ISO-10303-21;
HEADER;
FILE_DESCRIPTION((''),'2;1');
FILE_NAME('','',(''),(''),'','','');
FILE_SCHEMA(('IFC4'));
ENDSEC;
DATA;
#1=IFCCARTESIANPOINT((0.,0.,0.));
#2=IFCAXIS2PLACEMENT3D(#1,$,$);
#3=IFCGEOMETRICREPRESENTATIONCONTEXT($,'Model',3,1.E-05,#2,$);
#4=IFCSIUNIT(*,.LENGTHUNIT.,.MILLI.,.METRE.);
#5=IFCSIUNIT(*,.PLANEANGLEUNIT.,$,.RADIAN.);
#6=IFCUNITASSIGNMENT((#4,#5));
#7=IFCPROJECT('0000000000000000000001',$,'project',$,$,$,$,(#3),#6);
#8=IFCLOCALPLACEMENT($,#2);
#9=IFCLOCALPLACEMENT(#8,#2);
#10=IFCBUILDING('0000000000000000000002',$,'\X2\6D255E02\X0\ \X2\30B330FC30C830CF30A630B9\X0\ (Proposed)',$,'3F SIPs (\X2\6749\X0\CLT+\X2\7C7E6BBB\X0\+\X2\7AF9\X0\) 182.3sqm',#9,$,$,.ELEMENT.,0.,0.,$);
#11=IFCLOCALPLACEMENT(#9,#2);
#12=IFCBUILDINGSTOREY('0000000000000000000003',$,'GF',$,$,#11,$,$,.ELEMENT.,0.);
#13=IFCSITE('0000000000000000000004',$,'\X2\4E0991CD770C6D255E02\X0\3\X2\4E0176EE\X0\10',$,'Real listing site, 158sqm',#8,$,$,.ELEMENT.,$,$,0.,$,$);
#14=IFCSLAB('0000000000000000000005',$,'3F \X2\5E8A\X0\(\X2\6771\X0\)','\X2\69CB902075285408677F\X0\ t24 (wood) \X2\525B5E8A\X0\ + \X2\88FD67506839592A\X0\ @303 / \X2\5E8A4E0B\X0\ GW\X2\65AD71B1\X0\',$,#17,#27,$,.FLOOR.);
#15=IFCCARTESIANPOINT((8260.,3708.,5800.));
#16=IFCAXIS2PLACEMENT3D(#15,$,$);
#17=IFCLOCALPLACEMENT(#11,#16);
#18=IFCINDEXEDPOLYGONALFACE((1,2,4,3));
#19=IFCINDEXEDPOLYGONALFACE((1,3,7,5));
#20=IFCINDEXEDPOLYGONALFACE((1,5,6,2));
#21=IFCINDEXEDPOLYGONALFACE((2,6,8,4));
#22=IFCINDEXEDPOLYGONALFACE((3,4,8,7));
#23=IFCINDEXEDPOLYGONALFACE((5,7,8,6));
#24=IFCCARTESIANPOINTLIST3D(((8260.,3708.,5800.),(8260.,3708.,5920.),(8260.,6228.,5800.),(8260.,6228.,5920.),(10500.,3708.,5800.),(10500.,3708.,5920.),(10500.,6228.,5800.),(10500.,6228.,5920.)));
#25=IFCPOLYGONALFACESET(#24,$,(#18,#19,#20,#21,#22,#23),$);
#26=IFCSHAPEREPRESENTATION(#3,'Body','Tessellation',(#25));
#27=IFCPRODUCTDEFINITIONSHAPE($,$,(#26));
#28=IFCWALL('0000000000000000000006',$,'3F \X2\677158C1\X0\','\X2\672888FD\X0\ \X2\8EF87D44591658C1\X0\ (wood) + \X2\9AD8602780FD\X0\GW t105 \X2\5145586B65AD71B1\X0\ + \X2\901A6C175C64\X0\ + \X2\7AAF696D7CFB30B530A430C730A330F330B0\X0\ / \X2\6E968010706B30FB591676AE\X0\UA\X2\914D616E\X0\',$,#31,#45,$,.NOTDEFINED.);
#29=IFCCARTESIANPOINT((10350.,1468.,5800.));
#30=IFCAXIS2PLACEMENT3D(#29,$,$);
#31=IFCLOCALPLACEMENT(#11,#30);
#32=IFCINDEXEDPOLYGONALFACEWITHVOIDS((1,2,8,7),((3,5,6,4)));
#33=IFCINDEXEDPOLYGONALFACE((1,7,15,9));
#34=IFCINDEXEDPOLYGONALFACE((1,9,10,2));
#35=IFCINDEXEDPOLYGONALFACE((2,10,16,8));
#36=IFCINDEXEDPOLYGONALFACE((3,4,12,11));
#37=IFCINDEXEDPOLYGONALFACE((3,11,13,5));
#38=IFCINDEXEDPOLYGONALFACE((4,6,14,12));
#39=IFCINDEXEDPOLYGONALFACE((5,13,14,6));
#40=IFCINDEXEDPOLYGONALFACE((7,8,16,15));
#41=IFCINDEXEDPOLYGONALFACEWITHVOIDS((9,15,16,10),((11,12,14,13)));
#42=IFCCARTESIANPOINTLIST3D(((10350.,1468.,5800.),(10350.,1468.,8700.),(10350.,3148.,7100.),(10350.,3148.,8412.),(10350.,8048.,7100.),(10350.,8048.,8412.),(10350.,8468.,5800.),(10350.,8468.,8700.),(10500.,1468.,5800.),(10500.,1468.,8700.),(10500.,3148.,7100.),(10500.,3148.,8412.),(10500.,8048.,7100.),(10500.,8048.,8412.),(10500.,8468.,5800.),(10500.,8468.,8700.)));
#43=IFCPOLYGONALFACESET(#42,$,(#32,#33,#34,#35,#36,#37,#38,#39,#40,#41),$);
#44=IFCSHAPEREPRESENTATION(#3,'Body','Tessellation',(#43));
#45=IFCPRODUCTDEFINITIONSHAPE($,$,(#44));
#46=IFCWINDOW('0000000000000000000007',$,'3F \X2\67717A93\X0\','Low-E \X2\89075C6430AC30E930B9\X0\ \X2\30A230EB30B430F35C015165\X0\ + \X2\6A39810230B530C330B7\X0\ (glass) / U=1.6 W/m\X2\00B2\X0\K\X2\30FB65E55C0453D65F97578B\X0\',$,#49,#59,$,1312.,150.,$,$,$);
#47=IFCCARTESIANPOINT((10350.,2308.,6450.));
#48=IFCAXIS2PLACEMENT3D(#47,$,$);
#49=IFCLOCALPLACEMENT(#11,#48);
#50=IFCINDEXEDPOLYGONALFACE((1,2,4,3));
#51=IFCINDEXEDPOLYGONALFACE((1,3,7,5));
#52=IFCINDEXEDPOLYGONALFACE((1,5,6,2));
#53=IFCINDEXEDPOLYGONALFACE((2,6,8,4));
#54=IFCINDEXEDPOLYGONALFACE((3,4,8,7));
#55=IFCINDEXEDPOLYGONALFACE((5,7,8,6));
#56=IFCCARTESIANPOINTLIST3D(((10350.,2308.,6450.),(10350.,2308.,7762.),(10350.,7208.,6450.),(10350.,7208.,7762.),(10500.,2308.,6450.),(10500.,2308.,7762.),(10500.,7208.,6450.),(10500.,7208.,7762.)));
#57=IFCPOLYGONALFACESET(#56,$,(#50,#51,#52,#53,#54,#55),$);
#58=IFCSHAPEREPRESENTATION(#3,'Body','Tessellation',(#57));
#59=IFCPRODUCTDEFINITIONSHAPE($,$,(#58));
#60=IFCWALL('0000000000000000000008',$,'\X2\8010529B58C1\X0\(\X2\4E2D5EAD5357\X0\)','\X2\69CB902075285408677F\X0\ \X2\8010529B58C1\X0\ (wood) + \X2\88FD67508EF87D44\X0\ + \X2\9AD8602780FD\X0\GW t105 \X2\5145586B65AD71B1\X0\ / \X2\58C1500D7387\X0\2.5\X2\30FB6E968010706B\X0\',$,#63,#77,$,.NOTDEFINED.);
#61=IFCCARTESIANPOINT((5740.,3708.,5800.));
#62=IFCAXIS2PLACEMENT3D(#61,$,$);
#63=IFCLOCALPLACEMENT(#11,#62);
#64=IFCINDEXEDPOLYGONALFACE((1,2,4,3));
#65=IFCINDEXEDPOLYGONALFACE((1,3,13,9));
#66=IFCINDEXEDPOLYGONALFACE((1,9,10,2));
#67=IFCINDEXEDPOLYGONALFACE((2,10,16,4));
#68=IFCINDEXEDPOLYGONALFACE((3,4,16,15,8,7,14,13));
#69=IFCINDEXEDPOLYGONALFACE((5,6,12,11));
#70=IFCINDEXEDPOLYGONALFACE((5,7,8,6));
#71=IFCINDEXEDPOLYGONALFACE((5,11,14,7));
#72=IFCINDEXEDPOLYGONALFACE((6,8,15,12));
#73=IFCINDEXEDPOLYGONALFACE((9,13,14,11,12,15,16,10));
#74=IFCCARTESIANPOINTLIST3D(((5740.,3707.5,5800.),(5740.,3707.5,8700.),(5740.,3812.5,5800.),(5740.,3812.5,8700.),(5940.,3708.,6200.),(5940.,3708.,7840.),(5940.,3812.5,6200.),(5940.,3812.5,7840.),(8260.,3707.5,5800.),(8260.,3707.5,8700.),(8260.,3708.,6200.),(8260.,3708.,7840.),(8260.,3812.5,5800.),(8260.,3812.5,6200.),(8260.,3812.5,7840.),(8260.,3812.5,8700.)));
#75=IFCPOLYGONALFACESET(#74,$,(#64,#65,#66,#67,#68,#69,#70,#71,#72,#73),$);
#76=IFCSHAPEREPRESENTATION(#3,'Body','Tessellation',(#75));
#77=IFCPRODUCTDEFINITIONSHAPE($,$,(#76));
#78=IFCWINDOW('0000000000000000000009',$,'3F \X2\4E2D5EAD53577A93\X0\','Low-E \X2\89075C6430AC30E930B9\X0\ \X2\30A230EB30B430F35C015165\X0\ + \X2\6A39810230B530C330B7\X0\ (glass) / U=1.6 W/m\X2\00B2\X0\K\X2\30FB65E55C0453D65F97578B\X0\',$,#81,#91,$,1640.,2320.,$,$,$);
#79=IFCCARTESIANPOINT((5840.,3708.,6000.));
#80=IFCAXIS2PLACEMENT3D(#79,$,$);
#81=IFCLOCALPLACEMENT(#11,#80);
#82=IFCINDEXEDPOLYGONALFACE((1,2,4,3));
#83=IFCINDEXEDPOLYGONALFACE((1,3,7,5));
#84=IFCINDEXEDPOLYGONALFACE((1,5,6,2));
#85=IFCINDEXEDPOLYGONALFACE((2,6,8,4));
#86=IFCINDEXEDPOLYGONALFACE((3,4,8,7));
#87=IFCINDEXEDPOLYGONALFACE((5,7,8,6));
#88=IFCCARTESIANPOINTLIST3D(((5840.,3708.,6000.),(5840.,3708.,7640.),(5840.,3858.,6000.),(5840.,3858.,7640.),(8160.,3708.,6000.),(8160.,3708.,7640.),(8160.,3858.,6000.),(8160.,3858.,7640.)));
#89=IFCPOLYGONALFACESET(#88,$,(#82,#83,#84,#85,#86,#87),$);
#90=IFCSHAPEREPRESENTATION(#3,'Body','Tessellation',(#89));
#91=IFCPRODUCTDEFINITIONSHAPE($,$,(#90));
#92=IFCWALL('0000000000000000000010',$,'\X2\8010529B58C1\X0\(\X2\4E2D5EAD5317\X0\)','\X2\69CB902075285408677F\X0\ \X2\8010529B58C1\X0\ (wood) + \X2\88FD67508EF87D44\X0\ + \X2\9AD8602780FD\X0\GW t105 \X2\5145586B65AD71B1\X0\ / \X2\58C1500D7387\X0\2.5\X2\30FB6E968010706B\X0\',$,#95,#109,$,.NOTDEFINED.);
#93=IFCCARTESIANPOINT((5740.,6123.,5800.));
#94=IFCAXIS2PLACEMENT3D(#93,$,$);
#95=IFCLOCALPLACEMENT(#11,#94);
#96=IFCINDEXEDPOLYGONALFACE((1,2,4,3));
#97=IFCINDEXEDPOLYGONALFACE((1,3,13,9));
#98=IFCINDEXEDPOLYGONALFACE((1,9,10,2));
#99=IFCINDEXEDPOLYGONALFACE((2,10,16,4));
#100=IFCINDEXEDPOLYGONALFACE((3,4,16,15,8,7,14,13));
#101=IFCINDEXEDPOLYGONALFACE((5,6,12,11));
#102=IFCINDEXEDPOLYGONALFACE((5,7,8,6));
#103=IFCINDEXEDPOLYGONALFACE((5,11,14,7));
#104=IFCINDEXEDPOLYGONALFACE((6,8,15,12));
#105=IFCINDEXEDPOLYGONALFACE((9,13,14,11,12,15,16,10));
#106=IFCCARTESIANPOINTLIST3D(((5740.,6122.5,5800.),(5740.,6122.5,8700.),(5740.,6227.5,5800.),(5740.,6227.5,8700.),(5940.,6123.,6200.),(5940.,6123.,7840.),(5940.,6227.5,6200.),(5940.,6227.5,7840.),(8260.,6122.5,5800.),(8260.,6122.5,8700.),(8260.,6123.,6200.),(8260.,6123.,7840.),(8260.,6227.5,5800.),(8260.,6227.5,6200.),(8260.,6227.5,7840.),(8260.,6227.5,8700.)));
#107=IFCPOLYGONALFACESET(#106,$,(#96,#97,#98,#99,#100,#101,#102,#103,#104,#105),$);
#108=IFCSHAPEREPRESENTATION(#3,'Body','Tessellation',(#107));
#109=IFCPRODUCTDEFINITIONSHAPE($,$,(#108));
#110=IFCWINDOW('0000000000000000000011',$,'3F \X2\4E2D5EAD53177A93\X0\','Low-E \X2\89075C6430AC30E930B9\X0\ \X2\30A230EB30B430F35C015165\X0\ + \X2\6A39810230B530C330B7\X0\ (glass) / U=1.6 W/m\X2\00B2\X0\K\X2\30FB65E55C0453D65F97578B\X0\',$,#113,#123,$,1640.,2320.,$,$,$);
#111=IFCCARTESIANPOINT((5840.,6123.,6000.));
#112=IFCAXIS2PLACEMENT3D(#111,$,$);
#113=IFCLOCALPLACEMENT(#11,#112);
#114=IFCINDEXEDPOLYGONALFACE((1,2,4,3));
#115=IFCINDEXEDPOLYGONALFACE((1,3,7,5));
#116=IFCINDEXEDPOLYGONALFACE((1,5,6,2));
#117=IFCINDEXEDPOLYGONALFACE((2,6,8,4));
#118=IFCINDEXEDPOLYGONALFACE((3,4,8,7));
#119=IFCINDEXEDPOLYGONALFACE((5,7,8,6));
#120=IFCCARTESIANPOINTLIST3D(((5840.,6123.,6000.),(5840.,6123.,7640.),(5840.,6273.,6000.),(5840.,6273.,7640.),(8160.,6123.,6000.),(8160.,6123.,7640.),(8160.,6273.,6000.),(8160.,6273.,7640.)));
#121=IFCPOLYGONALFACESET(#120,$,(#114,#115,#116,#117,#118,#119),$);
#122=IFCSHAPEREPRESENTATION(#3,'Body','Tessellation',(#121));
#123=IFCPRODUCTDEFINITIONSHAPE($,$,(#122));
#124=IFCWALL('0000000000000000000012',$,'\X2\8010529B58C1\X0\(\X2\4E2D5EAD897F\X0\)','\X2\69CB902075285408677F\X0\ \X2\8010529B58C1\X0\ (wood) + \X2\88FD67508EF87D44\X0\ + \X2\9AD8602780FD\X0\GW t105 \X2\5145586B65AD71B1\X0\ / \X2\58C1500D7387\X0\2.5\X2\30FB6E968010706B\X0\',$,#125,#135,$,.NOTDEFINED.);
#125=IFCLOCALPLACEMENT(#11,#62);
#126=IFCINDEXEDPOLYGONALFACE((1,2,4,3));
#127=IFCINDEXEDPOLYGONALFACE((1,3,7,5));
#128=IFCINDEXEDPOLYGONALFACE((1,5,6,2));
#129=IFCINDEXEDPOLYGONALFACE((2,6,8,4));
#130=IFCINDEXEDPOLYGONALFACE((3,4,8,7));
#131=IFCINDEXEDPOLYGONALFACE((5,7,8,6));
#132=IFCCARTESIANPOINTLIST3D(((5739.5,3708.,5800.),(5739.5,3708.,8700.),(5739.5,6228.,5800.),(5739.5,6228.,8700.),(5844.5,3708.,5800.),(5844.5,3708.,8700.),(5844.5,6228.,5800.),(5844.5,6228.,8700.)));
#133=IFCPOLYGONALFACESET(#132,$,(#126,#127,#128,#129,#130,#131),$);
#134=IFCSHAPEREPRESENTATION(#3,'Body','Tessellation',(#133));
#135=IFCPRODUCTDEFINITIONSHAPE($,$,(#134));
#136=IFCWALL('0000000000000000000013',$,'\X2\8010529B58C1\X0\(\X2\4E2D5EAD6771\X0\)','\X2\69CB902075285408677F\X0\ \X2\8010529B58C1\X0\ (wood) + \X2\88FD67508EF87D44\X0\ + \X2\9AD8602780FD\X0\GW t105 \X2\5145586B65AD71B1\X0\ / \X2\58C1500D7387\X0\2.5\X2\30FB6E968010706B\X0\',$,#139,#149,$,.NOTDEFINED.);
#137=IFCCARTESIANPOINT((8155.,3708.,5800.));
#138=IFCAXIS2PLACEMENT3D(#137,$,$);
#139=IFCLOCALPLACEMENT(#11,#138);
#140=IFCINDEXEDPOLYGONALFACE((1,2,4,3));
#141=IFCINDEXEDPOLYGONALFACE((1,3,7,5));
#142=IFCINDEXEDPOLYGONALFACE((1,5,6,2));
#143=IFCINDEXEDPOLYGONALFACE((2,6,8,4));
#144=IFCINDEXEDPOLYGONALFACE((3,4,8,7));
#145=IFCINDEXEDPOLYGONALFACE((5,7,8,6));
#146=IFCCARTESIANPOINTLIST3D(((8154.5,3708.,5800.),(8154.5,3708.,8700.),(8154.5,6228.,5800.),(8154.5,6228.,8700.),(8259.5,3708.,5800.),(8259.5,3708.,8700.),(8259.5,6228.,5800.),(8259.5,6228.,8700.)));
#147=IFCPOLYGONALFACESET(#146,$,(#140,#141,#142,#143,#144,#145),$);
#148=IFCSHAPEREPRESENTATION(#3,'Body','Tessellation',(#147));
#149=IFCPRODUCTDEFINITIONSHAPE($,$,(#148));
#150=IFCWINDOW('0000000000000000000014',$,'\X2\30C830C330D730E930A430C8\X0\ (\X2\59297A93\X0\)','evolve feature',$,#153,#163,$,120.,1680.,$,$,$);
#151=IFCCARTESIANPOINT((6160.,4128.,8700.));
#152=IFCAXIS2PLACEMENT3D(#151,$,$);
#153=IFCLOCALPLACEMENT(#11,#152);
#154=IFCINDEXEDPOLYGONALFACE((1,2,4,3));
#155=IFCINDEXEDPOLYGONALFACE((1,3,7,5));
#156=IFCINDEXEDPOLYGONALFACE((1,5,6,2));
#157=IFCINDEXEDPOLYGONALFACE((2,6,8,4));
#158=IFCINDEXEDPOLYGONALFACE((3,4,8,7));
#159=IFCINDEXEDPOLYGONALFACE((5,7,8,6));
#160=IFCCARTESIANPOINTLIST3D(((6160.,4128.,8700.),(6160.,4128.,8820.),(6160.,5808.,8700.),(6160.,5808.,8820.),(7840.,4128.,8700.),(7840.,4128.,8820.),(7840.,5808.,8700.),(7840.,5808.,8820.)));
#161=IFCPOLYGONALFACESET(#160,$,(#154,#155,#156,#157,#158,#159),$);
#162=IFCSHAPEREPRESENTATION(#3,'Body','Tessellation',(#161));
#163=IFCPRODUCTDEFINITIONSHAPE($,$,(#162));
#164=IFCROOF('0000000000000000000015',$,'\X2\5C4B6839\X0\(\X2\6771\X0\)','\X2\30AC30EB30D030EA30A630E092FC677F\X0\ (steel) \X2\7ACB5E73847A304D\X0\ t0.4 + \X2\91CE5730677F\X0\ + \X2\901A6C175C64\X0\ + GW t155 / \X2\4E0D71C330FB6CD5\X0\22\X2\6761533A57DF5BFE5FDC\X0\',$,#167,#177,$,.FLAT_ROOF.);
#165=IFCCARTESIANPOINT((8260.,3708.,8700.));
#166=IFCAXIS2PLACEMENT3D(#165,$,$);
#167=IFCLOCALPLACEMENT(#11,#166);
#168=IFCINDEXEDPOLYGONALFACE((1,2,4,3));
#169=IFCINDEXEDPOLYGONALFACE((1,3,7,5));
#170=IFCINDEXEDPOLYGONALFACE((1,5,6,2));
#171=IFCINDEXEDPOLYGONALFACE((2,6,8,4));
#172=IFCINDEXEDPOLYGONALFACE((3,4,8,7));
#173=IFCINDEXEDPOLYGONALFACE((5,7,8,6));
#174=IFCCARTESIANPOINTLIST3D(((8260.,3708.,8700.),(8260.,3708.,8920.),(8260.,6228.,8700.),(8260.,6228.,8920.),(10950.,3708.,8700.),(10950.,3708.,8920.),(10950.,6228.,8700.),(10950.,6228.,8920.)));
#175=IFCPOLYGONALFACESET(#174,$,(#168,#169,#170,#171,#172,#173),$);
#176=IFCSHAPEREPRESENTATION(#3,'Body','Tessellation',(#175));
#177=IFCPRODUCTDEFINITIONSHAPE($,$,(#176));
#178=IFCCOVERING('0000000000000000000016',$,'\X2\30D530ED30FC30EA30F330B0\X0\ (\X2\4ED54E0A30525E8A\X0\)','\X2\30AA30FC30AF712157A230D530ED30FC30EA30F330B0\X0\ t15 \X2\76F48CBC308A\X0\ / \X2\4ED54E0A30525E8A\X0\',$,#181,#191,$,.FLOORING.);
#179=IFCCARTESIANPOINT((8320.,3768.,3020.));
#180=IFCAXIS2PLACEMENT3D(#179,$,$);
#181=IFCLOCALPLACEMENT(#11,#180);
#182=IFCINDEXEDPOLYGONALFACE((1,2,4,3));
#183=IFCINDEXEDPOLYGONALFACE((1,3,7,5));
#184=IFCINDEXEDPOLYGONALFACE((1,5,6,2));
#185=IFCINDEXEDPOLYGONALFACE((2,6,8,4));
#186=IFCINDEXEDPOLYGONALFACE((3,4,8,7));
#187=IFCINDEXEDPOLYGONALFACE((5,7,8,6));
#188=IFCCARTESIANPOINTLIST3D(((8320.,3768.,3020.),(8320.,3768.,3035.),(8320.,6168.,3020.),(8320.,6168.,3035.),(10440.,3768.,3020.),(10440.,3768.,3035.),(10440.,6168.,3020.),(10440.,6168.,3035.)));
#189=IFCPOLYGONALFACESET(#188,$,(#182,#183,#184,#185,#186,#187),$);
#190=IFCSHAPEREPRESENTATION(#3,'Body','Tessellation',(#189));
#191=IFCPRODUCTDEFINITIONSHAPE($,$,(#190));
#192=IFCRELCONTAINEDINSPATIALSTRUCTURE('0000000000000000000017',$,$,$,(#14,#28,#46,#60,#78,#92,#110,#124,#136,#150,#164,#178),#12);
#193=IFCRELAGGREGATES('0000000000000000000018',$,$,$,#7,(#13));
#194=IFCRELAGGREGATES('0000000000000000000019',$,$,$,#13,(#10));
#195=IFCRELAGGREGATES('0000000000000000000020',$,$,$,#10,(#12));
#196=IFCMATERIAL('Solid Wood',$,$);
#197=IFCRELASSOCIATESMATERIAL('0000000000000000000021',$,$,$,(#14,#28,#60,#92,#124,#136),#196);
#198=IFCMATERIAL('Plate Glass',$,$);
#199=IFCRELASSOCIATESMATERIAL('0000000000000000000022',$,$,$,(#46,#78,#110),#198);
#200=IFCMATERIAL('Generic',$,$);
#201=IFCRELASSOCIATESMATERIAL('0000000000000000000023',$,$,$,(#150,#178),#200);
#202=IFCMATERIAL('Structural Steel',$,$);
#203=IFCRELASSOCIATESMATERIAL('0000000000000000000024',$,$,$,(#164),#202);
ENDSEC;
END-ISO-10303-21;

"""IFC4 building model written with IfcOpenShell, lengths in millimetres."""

from ifc_helpers import new_model, si_unit, frame, frame_2d, origin, place, context, project, spatial, rectangle, extrude, material, element, fill, save


model = new_model("IFC4")

# Units and contexts
model_context = context("Model", 3, precision=1e-05, world=origin())
ifc_project = project(units=[si_unit("LENGTHUNIT", "METRE", prefix="MILLI"), si_unit("PLANEANGLEUNIT", "RADIAN")], contexts=[model_context])

# Site, building, storey
site_placement = place(None, origin())
site = spatial("IfcSite", under=ifc_project, at=site_placement, Name="三重県津市3丁目10", ObjectType="Real listing site, 158sqm", CompositionType="ELEMENT", RefElevation=0.0)
building_placement = place(site_placement, origin())
building = spatial("IfcBuilding", under=site, at=building_placement, Name="津市 コートハウス (Proposed)", ObjectType="3F SIPs (杉CLT+籾殻+竹) 182.3sqm", CompositionType="ELEMENT", ElevationOfRefHeight=0.0, ElevationOfTerrain=0.0)
storey_placement = place(building_placement, origin())
storey = spatial("IfcBuildingStorey", under=building, at=storey_placement, Name="GF", CompositionType="ELEMENT", Elevation=0.0)

# Slab
ifc_material_1 = material(Name="Solid Wood")
slab_placement = place(storey_placement, frame((8260.0, 3708.0, 5800.0)))
element("IfcSlab", 1, at=slab_placement, inside=storey, material=ifc_material_1, Name="3F 床(東)", Description="構造用合板 t24 (wood) 剛床 + 製材根太 @303 / 床下 GW断熱", PredefinedType="FLOOR", context=model_context, shape_type="SweptSolid", body=[
    extrude(rectangle(XDim=2240.0, YDim=2520.0, at=frame_2d((1120.0, 1260.0))), frame((8260.0, 3708.0, 5800.0)), (0.0, 0.0, 1.0), 120.0),
])

# Walls, openings, windows
wall_1_placement = place(storey_placement, frame((10350.0, 1468.0, 5800.0)))
wall_1 = element("IfcWall", 2, at=wall_1_placement, inside=storey, material=ifc_material_1, Name="3F 東壁", Description="木製 軸組外壁 (wood) + 高性能GW t105 充填断熱 + 通気層 + 窯業系サイディング / 準耐火・外皮UA配慮", PredefinedType="NOTDEFINED", context=model_context, shape_type="SweptSolid", body=[
    extrude(rectangle(XDim=150.0, YDim=7000.0, at=frame_2d((75.0, 3500.0))), frame((10350.0, 1468.0, 5800.0)), (0.0, 0.0, 1.0), 2900.0),
])
opening_1_placement = place(storey_placement, frame((10350.0, 2308.0, 6450.0)))
opening_1 = element("IfcOpeningElement", 3, at=opening_1_placement, cuts=wall_1, PredefinedType="NOTDEFINED", context=model_context, shape_type="SweptSolid", body=[
    extrude(rectangle(XDim=150.0, YDim=4900.0, at=frame_2d((75.0, 2450.0))), frame((10350.0, 2308.0, 6450.0)), (0.0, 0.0, 1.0), 1312.0),
])
ifc_material_2 = material(Name="Plate Glass")
window_1_placement = place(storey_placement, frame((10350.0, 2308.0, 6450.0)))
window_1 = element("IfcWindow", 4, at=window_1_placement, inside=storey, material=ifc_material_2, Name="3F 東窓", Description="Low-E 複層ガラス アルゴン封入 + 樹脂サッシ (glass) / U=1.6 W/m²K・日射取得型", OverallHeight=1312.0, OverallWidth=150.0, context=model_context, shape_type="SweptSolid", body=[
    extrude(rectangle(XDim=150.0, YDim=4900.0, at=frame_2d((75.0, 2450.0))), frame((10350.0, 2308.0, 6450.0)), (0.0, 0.0, 1.0), 1312.0),
])
fill(opening_1, window_1)
wall_2_placement = place(storey_placement, frame((5740.0, 3708.0, 5800.0)))
wall_2 = element("IfcWall", 5, at=wall_2_placement, inside=storey, material=ifc_material_1, Name="耐力壁(中庭南)", Description="構造用合板 耐力壁 (wood) + 製材軸組 + 高性能GW t105 充填断熱 / 壁倍率2.5・準耐火", PredefinedType="NOTDEFINED", context=model_context, shape_type="SweptSolid", body=[
    extrude(rectangle(XDim=2520.0, YDim=105.0, at=frame_2d((1260.0, 52.0))), frame((5740.0, 3708.0, 5800.0)), (0.0, 0.0, 1.0), 2900.0),
])
opening_2_placement = place(storey_placement, frame((5840.0, 3708.0, 6000.0)))
opening_2 = element("IfcOpeningElement", 6, at=opening_2_placement, cuts=wall_2, PredefinedType="NOTDEFINED", context=model_context, shape_type="SweptSolid", body=[
    extrude(rectangle(XDim=2320.0, YDim=150.0, at=frame_2d((1160.0, 75.0))), frame((5840.0, 3708.0, 6000.0)), (0.0, 0.0, 1.0), 1640.0),
])
window_2_placement = place(storey_placement, frame((5840.0, 3708.0, 6000.0)))
window_2 = element("IfcWindow", 7, at=window_2_placement, inside=storey, material=ifc_material_2, Name="3F 中庭南窓", Description="Low-E 複層ガラス アルゴン封入 + 樹脂サッシ (glass) / U=1.6 W/m²K・日射取得型", OverallHeight=1640.0, OverallWidth=2320.0, context=model_context, shape_type="SweptSolid", body=[
    extrude(rectangle(XDim=2320.0, YDim=150.0, at=frame_2d((1160.0, 75.0))), frame((5840.0, 3708.0, 6000.0)), (0.0, 0.0, 1.0), 1640.0),
])
fill(opening_2, window_2)
wall_3_placement = place(storey_placement, frame((5740.0, 6123.0, 5800.0)))
wall_3 = element("IfcWall", 8, at=wall_3_placement, inside=storey, material=ifc_material_1, Name="耐力壁(中庭北)", Description="構造用合板 耐力壁 (wood) + 製材軸組 + 高性能GW t105 充填断熱 / 壁倍率2.5・準耐火", PredefinedType="NOTDEFINED", context=model_context, shape_type="SweptSolid", body=[
    extrude(rectangle(XDim=2520.0, YDim=105.0, at=frame_2d((1260.0, 52.0))), frame((5740.0, 6123.0, 5800.0)), (0.0, 0.0, 1.0), 2900.0),
])
opening_3_placement = place(storey_placement, frame((5840.0, 6123.0, 6000.0)))
opening_3 = element("IfcOpeningElement", 9, at=opening_3_placement, cuts=wall_3, PredefinedType="NOTDEFINED", context=model_context, shape_type="SweptSolid", body=[
    extrude(rectangle(XDim=2320.0, YDim=150.0, at=frame_2d((1160.0, 75.0))), frame((5840.0, 6123.0, 6000.0)), (0.0, 0.0, 1.0), 1640.0),
])
window_3_placement = place(storey_placement, frame((5840.0, 6123.0, 6000.0)))
window_3 = element("IfcWindow", 10, at=window_3_placement, inside=storey, material=ifc_material_2, Name="3F 中庭北窓", Description="Low-E 複層ガラス アルゴン封入 + 樹脂サッシ (glass) / U=1.6 W/m²K・日射取得型", OverallHeight=1640.0, OverallWidth=2320.0, context=model_context, shape_type="SweptSolid", body=[
    extrude(rectangle(XDim=2320.0, YDim=150.0, at=frame_2d((1160.0, 75.0))), frame((5840.0, 6123.0, 6000.0)), (0.0, 0.0, 1.0), 1640.0),
])
fill(opening_3, window_3)

# Walls
wall_4_placement = place(storey_placement, frame((5740.0, 3708.0, 5800.0)))
element("IfcWall", 11, at=wall_4_placement, inside=storey, material=ifc_material_1, Name="耐力壁(中庭西)", Description="構造用合板 耐力壁 (wood) + 製材軸組 + 高性能GW t105 充填断熱 / 壁倍率2.5・準耐火", PredefinedType="NOTDEFINED", context=model_context, shape_type="SweptSolid", body=[
    extrude(rectangle(XDim=105.0, YDim=2520.0, at=frame_2d((52.0, 1260.0))), frame((5740.0, 3708.0, 5800.0)), (0.0, 0.0, 1.0), 2900.0),
])
wall_5_placement = place(storey_placement, frame((8155.0, 3708.0, 5800.0)))
element("IfcWall", 12, at=wall_5_placement, inside=storey, material=ifc_material_1, Name="耐力壁(中庭東)", Description="構造用合板 耐力壁 (wood) + 製材軸組 + 高性能GW t105 充填断熱 / 壁倍率2.5・準耐火", PredefinedType="NOTDEFINED", context=model_context, shape_type="SweptSolid", body=[
    extrude(rectangle(XDim=105.0, YDim=2520.0, at=frame_2d((52.0, 1260.0))), frame((8155.0, 3708.0, 5800.0)), (0.0, 0.0, 1.0), 2900.0),
])

# Window
ifc_material_3 = material(Name="Generic")
window_4_placement = place(storey_placement, frame((6160.0, 4128.0, 8700.0)))
element("IfcWindow", 13, at=window_4_placement, inside=storey, material=ifc_material_3, Name="トップライト (天窓)", Description="evolve feature", OverallHeight=120.0, OverallWidth=1680.0, context=model_context, shape_type="SweptSolid", body=[
    extrude(rectangle(XDim=1680.0, YDim=1680.0, at=frame_2d((840.0, 840.0))), frame((6160.0, 4128.0, 8700.0)), (0.0, 0.0, 1.0), 120.0),
])

# Roof
ifc_material_4 = material(Name="Structural Steel")
for number, where, name in (
    (14, (8260.0, 3708.0, 8700.0), "屋根(東)"),
):
    element("IfcRoof", number, at=place(storey_placement, frame(where)), inside=storey, material=ifc_material_4, Name=name, Description="ガルバリウム鋼板 (steel) 立平葺き t0.4 + 野地板 + 通気層 + GW t155 / 不燃・法22条区域対応", PredefinedType="FLAT_ROOF", context=model_context, shape_type="SweptSolid", body=[
        extrude(rectangle(XDim=2690.0, YDim=2520.0, at=frame_2d((1345.0, 1260.0))), frame((8260.0, 3708.0, 8700.0)), (0.0, 0.0, 1.0), 220.0),
    ])

# Covering
covering_1_placement = place(storey_placement, frame((8320.0, 3768.0, 3020.0)))
element("IfcCovering", 15, at=covering_1_placement, inside=storey, material=ifc_material_3, Name="フローリング (仕上げ床)", Description="オーク無垢フローリング t15 直貼り / 仕上げ床", PredefinedType="FLOORING", context=model_context, shape_type="SweptSolid", body=[
    extrude(rectangle(XDim=2120.0, YDim=2400.0, at=frame_2d((1060.0, 1200.0))), frame((8320.0, 3768.0, 3020.0)), (0.0, 0.0, 1.0), 15.0),
])

save(model, "model.ifc")
